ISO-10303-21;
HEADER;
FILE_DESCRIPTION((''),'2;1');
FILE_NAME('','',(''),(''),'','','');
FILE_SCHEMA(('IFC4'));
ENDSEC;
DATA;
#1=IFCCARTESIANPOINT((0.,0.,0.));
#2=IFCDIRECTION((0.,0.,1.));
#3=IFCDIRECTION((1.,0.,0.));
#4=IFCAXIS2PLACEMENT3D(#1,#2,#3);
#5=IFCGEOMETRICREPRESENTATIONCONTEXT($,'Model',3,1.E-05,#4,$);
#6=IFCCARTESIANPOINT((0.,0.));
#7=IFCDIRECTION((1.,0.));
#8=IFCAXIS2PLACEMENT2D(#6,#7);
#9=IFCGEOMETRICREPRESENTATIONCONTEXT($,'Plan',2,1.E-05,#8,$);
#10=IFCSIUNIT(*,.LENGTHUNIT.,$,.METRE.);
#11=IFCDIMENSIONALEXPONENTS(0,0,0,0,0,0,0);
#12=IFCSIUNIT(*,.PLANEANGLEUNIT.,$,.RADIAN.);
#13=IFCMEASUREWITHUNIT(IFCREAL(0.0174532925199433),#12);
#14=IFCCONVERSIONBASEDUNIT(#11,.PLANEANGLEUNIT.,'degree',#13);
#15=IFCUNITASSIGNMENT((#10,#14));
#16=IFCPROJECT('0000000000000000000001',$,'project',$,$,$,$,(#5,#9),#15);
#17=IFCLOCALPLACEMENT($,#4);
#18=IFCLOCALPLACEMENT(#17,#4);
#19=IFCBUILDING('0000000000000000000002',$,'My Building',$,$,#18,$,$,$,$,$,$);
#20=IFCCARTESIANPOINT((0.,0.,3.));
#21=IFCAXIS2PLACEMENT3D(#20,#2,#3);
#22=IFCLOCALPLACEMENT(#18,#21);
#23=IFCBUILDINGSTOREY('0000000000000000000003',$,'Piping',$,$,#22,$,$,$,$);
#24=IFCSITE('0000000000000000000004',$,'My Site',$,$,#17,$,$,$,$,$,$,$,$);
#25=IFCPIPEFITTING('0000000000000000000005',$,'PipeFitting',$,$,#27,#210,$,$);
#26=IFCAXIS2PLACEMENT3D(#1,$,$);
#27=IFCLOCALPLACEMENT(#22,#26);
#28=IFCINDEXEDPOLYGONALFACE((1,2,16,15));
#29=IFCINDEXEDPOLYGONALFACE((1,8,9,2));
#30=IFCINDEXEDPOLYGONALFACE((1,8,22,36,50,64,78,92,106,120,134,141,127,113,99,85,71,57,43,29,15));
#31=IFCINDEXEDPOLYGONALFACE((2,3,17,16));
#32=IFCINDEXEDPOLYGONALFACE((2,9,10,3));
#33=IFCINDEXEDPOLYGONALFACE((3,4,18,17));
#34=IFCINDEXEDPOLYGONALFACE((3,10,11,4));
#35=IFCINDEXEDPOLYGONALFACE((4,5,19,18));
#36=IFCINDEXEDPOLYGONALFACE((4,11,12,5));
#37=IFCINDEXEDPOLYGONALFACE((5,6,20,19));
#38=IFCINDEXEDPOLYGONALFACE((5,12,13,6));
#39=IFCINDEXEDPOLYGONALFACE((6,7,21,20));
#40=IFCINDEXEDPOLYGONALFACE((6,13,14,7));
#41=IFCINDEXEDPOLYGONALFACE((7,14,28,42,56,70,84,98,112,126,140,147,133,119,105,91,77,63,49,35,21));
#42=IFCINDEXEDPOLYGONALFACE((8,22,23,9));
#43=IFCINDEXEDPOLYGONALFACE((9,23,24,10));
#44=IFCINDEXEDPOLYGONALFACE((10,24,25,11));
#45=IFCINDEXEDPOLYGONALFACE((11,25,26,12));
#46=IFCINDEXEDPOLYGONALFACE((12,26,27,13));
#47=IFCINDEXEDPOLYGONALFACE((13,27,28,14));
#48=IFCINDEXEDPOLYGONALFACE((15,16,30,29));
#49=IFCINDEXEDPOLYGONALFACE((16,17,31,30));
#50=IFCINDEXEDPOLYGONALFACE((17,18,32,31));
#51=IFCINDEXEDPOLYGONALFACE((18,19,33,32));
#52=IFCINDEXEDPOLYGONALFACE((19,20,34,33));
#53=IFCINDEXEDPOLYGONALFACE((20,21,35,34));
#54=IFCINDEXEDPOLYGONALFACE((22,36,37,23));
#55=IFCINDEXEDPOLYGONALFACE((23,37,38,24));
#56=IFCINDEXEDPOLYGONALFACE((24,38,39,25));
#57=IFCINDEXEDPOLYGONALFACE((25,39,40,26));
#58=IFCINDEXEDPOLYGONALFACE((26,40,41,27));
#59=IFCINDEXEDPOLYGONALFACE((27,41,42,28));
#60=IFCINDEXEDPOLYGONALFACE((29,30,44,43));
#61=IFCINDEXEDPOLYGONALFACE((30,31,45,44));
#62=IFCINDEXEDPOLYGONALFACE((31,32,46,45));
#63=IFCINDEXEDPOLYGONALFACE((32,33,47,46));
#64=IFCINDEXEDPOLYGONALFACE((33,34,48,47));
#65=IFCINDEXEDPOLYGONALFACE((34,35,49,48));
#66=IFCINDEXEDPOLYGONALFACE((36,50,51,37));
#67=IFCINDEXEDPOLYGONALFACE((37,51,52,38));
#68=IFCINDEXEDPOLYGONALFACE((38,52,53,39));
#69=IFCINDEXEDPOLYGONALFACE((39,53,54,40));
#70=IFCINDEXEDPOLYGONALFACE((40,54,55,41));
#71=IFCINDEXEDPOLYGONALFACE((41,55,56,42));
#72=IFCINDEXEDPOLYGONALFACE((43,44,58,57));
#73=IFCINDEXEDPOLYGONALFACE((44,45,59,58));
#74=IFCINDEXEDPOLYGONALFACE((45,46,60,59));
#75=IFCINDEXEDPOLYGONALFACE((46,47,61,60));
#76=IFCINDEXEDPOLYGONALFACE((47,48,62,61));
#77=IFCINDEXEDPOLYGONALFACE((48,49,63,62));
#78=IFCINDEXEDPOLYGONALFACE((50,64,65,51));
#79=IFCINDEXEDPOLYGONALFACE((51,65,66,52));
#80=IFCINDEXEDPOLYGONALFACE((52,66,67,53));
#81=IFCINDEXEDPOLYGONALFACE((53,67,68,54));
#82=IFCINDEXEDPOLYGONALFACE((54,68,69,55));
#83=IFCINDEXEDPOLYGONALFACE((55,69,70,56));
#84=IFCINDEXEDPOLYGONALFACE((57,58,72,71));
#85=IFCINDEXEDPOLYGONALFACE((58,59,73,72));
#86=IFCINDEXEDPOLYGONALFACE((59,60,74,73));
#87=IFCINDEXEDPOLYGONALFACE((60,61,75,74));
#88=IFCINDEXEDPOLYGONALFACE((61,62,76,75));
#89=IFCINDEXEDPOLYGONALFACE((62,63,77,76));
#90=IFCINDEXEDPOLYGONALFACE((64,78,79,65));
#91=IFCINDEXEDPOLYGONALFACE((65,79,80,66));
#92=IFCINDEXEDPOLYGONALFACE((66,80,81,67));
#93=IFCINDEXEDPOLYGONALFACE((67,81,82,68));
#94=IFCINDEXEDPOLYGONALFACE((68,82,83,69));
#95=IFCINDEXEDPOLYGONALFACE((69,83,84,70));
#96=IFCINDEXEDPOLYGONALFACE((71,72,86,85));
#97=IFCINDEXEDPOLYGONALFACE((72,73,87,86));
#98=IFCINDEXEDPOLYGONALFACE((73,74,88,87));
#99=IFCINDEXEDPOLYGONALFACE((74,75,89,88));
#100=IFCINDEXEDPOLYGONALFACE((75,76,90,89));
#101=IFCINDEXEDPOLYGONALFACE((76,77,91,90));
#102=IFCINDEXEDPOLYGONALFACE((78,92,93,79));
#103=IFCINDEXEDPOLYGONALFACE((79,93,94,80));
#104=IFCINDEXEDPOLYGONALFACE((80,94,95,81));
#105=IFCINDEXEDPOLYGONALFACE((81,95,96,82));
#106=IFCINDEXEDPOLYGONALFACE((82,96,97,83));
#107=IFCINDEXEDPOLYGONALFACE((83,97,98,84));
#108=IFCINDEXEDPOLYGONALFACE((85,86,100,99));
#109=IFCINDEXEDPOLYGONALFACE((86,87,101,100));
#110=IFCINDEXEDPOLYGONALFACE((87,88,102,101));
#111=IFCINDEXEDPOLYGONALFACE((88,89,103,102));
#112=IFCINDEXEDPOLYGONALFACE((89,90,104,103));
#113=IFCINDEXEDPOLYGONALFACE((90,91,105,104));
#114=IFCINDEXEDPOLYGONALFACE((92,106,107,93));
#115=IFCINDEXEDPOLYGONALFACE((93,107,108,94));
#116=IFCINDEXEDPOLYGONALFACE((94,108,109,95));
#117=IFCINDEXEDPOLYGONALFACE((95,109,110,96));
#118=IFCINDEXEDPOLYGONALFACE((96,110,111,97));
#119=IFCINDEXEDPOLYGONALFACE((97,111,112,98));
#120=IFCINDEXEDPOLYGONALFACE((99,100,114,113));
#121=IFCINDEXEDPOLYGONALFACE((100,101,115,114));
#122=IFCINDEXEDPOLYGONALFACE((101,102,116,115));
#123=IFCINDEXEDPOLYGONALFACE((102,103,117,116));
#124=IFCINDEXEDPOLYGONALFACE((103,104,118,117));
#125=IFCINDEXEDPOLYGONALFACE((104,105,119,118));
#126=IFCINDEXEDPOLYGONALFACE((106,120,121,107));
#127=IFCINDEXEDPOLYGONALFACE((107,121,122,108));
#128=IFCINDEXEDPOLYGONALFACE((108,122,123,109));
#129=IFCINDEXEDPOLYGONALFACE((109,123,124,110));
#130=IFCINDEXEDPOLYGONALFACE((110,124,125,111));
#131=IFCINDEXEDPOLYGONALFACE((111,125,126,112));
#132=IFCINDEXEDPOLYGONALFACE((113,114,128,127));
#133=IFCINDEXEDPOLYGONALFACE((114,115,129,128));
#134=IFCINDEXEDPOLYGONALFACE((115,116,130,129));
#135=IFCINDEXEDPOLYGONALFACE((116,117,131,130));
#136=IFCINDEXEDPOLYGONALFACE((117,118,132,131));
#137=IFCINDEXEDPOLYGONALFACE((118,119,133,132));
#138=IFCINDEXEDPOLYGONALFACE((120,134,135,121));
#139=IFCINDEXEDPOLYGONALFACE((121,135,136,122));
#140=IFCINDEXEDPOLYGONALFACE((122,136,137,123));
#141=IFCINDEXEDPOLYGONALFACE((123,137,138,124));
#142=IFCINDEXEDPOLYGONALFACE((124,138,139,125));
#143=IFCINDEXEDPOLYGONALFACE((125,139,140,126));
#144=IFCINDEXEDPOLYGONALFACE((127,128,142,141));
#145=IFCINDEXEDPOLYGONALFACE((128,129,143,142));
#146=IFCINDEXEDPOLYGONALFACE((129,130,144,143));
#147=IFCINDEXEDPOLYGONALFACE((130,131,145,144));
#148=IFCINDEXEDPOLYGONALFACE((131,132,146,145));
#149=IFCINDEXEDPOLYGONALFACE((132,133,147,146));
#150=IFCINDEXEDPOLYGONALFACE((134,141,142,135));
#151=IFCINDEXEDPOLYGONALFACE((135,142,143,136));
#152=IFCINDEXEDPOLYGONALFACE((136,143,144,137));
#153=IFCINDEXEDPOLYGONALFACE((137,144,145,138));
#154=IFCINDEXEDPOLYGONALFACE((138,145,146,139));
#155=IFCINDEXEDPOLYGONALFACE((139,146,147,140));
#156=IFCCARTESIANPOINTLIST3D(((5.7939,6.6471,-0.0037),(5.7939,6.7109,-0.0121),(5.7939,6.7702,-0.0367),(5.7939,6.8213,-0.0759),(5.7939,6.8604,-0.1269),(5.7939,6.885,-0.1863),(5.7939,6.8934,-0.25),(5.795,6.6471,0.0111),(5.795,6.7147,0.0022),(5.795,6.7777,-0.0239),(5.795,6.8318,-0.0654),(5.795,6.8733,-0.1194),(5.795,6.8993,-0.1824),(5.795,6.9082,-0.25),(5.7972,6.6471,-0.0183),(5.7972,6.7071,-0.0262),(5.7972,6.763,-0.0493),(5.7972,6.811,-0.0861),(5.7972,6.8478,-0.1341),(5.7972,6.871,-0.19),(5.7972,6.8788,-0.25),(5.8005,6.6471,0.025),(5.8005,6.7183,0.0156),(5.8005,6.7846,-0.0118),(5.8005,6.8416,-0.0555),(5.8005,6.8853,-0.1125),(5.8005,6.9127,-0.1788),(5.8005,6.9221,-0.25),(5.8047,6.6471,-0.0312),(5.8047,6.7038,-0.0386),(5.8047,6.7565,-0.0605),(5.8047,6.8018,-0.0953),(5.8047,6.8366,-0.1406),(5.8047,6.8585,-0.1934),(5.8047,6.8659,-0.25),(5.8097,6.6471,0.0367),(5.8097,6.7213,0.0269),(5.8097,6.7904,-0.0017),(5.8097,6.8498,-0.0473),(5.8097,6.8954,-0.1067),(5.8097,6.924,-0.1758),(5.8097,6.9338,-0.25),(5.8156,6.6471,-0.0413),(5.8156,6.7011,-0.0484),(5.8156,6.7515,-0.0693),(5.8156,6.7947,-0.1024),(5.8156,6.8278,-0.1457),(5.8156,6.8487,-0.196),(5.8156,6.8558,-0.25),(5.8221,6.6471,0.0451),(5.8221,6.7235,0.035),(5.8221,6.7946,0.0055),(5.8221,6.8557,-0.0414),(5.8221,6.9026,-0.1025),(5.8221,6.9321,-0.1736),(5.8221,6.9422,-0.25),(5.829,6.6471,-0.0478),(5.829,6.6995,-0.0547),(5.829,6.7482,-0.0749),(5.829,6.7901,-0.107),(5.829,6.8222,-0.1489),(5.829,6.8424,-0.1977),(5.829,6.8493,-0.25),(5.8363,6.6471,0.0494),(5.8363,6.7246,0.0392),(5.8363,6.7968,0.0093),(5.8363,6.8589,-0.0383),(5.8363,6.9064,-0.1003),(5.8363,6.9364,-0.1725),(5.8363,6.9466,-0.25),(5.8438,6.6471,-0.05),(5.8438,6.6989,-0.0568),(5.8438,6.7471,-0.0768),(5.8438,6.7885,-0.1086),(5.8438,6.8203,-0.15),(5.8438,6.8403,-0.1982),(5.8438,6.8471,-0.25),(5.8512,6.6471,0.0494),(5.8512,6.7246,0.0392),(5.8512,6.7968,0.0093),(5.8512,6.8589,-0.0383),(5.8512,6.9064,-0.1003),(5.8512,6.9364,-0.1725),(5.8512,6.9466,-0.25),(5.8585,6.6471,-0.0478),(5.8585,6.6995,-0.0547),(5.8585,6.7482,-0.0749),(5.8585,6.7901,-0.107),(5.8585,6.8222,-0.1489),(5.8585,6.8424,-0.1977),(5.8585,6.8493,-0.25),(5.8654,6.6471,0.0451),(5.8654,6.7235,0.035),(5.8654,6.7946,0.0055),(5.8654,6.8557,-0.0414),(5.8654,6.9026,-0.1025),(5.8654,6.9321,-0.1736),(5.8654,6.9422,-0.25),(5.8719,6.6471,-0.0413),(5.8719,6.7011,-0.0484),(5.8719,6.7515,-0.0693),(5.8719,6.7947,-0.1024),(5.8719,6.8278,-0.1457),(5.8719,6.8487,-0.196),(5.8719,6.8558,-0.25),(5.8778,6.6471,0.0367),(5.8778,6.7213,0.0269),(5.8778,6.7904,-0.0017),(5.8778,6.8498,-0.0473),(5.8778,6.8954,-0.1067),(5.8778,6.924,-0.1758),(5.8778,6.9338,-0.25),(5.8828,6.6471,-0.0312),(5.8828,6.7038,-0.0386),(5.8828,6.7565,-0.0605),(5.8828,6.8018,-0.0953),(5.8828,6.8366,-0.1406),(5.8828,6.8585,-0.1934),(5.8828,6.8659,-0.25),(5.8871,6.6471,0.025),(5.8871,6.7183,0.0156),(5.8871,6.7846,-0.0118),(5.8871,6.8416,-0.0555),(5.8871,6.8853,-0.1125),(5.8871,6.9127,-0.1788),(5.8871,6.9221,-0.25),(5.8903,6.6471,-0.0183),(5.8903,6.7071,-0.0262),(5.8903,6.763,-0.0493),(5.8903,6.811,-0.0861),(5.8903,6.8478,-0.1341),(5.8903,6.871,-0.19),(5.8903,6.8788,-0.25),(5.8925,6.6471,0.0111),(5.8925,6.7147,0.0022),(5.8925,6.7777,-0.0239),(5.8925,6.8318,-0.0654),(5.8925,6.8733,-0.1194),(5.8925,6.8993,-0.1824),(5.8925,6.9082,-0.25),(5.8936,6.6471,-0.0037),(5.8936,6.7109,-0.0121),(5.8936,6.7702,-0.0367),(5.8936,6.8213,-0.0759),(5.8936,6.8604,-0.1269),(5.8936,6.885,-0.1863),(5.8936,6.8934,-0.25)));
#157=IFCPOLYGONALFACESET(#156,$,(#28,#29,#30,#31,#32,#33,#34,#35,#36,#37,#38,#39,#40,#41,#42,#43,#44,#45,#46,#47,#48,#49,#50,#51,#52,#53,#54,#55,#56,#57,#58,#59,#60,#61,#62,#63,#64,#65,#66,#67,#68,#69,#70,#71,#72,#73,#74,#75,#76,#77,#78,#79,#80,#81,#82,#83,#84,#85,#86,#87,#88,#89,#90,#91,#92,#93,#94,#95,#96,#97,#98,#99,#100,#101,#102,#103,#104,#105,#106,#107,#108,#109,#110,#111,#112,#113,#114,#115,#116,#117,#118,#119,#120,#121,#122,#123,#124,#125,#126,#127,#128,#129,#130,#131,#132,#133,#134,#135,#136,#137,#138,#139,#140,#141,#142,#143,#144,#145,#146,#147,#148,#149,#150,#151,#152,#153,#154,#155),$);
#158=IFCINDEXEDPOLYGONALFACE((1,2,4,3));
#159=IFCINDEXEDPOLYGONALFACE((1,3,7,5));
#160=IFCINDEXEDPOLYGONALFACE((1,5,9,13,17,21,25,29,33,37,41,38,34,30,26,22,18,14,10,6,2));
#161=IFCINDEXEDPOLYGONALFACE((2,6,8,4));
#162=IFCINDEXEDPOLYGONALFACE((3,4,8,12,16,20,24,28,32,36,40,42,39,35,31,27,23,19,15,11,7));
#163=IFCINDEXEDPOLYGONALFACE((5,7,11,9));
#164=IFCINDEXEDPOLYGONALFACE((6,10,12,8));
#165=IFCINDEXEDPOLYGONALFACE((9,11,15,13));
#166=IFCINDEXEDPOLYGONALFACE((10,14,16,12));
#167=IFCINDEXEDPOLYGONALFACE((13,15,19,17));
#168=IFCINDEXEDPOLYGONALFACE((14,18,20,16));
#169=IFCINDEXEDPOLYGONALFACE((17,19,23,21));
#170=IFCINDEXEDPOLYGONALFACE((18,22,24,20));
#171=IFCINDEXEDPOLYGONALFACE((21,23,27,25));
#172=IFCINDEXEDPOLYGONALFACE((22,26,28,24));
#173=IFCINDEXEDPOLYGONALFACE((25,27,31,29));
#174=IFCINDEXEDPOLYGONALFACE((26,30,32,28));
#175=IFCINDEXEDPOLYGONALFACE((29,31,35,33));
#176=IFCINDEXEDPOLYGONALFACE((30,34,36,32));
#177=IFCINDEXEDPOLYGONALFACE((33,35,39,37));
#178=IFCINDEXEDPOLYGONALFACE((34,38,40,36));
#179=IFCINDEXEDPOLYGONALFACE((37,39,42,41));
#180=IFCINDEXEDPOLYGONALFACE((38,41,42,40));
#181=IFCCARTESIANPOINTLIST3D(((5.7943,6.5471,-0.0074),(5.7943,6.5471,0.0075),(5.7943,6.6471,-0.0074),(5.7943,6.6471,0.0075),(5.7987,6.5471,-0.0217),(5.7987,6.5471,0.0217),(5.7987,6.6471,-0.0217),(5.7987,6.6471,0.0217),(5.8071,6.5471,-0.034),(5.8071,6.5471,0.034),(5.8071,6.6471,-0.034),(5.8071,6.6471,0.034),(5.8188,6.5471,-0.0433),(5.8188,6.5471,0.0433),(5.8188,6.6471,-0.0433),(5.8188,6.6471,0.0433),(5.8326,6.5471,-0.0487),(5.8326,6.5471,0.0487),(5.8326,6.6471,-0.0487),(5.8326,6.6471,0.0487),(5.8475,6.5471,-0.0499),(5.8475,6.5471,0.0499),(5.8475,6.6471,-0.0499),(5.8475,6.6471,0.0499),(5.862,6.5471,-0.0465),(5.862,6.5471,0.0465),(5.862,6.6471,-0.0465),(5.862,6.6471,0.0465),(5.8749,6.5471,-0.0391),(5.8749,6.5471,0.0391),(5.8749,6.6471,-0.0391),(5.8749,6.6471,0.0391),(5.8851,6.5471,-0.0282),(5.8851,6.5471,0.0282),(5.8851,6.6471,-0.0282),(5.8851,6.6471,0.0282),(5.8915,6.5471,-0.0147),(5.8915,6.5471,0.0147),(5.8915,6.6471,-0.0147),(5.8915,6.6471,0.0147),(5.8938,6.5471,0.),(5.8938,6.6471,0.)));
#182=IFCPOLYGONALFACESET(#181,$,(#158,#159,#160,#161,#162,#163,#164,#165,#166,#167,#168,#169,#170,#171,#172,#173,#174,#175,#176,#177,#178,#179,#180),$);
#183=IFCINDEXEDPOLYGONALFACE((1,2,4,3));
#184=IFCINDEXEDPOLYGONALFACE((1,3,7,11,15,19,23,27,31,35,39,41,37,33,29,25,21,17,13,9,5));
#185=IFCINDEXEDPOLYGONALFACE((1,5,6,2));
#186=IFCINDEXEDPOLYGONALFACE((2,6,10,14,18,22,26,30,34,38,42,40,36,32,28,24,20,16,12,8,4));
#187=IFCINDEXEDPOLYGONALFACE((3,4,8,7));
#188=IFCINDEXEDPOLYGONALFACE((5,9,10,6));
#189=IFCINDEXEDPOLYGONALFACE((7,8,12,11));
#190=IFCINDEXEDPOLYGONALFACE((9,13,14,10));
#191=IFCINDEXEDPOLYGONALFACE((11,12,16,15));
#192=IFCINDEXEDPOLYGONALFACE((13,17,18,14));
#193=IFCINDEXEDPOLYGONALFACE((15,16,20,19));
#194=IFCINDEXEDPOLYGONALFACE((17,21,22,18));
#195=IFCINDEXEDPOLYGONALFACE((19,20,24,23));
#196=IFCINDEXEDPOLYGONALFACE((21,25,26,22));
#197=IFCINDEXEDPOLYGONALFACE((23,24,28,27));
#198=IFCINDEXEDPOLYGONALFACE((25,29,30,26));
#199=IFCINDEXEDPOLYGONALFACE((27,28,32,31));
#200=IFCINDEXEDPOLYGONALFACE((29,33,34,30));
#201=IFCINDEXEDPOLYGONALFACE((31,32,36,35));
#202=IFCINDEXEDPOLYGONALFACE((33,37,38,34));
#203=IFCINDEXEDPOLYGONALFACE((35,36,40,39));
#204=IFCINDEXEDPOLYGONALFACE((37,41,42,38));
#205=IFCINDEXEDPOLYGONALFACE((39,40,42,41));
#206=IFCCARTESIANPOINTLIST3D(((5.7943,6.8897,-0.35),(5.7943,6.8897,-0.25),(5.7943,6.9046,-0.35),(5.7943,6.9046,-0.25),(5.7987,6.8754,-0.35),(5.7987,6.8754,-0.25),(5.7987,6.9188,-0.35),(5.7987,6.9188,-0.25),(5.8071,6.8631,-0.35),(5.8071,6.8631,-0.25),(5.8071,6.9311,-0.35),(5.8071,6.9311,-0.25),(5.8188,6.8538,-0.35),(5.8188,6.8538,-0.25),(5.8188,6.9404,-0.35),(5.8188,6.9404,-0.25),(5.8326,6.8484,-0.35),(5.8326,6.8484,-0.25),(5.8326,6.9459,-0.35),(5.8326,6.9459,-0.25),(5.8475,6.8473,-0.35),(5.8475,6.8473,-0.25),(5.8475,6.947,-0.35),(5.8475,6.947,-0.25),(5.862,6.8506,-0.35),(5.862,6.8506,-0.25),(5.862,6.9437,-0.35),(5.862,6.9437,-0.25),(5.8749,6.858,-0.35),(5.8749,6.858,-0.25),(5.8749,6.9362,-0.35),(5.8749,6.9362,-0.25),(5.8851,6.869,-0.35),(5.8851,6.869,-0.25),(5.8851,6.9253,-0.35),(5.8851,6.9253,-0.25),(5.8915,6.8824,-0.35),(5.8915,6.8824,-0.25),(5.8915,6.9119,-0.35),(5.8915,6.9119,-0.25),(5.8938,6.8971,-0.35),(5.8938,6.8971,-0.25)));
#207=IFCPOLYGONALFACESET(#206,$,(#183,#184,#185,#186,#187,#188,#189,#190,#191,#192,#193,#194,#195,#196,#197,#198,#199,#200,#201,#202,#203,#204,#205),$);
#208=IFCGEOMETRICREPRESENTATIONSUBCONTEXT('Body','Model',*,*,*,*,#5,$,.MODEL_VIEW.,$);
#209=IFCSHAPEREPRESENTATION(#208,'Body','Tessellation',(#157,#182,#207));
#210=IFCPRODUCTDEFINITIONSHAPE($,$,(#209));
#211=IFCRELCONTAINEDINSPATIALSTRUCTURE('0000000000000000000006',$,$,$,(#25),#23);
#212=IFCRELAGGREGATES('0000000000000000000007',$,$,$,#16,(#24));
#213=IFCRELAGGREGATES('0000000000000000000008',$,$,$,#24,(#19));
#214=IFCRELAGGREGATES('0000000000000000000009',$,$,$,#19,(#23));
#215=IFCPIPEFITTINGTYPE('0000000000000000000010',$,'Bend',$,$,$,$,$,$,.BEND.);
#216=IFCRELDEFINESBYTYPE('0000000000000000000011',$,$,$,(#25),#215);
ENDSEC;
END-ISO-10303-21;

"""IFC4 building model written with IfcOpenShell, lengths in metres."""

from ifc_helpers import new_model, entity, si_unit, converted_unit, frame, origin_with_axes, origin_2d_with_axis, place, context, subcontext, project, spatial, circle, extrude, source, transform, mapped, type_object, type_shapes, element, save


model = new_model("IFC4")

# Units and contexts
model_context = context("Model", 3, precision=1e-05, world=origin_with_axes())
plan_context = context("Plan", 2, precision=1e-05, world=origin_2d_with_axis())
body_context = subcontext(model_context, "Body", "Model", "MODEL_VIEW")
ifc_project = project(units=[si_unit("LENGTHUNIT", "METRE"), converted_unit("PLANEANGLEUNIT", "degree", entity("IfcReal", 0.0174532925199433), si_unit("PLANEANGLEUNIT", "RADIAN"), dimensions=[0, 0, 0, 0, 0, 0, 0])], contexts=[model_context, plan_context])

# Site, building, storey
site_placement = place(None, origin_with_axes())
site = spatial("IfcSite", under=ifc_project, at=site_placement, Name="My Site")
building_placement = place(site_placement, origin_with_axes())
building = spatial("IfcBuilding", under=site, at=building_placement, Name="My Building")
storey_placement = place(building_placement, frame((0.0, 0.0, 3.0), z_axis=(0.0, 0.0, 1.0), x_axis=(1.0, 0.0, 0.0)))
storey = spatial("IfcBuildingStorey", under=building, at=storey_placement, Name="Piping")

# Pipe fitting
pipe_fitting_type = type_object("IfcPipeFittingType", Name="Bend", PredefinedType="BEND")
shared_shape = source(origin_with_axes(), body_context, "Body", "SolidModel", [
    entity("IfcSweptDiskSolid", entity("IfcIndexedPolyCurve", entity("IfcCartesianPointList3D", [[0.0, 0.0, -0.1], [0.0, -0.0732, -0.2768], [0.0, -0.25, -0.35]]), [entity("IfcArcIndex", [1, 2, 3])]), 0.05),
    extrude(circle(Radius=0.05), origin_with_axes(), (0.0, 0.0, -1.0), 0.1),
    extrude(circle(Radius=0.05), frame((0.0, -0.25, -0.35), z_axis=(0.0, -1.0, 0.0), x_axis=(1.0, 0.0, 0.0)), (0.0, 0.0, 1.0), 0.1),
])
type_shapes(pipe_fitting_type, [shared_shape])
for number, where, z_axis, x_axis, name in (
    (1, (5.8438, 6.5471, 0.0), (0.0, -1.0, 0.0), (1.0, 0.0, 0.0), "PipeFitting"),
):
    element("IfcPipeFitting", number, at=place(storey_placement, frame(where, z_axis=z_axis, x_axis=x_axis)), inside=storey, type_object=pipe_fitting_type, Name=name, context=body_context, shape_type="MappedRepresentation", body=[
        mapped(shared_shape, transform((0.0, 0.0, 0.0), x_axis=(1.0, 0.0, 0.0), y_axis=(0.0, 1.0, 0.0), z_axis=(0.0, 0.0, 1.0), scale=1.0)),
    ])

save(model, "model.ifc")
